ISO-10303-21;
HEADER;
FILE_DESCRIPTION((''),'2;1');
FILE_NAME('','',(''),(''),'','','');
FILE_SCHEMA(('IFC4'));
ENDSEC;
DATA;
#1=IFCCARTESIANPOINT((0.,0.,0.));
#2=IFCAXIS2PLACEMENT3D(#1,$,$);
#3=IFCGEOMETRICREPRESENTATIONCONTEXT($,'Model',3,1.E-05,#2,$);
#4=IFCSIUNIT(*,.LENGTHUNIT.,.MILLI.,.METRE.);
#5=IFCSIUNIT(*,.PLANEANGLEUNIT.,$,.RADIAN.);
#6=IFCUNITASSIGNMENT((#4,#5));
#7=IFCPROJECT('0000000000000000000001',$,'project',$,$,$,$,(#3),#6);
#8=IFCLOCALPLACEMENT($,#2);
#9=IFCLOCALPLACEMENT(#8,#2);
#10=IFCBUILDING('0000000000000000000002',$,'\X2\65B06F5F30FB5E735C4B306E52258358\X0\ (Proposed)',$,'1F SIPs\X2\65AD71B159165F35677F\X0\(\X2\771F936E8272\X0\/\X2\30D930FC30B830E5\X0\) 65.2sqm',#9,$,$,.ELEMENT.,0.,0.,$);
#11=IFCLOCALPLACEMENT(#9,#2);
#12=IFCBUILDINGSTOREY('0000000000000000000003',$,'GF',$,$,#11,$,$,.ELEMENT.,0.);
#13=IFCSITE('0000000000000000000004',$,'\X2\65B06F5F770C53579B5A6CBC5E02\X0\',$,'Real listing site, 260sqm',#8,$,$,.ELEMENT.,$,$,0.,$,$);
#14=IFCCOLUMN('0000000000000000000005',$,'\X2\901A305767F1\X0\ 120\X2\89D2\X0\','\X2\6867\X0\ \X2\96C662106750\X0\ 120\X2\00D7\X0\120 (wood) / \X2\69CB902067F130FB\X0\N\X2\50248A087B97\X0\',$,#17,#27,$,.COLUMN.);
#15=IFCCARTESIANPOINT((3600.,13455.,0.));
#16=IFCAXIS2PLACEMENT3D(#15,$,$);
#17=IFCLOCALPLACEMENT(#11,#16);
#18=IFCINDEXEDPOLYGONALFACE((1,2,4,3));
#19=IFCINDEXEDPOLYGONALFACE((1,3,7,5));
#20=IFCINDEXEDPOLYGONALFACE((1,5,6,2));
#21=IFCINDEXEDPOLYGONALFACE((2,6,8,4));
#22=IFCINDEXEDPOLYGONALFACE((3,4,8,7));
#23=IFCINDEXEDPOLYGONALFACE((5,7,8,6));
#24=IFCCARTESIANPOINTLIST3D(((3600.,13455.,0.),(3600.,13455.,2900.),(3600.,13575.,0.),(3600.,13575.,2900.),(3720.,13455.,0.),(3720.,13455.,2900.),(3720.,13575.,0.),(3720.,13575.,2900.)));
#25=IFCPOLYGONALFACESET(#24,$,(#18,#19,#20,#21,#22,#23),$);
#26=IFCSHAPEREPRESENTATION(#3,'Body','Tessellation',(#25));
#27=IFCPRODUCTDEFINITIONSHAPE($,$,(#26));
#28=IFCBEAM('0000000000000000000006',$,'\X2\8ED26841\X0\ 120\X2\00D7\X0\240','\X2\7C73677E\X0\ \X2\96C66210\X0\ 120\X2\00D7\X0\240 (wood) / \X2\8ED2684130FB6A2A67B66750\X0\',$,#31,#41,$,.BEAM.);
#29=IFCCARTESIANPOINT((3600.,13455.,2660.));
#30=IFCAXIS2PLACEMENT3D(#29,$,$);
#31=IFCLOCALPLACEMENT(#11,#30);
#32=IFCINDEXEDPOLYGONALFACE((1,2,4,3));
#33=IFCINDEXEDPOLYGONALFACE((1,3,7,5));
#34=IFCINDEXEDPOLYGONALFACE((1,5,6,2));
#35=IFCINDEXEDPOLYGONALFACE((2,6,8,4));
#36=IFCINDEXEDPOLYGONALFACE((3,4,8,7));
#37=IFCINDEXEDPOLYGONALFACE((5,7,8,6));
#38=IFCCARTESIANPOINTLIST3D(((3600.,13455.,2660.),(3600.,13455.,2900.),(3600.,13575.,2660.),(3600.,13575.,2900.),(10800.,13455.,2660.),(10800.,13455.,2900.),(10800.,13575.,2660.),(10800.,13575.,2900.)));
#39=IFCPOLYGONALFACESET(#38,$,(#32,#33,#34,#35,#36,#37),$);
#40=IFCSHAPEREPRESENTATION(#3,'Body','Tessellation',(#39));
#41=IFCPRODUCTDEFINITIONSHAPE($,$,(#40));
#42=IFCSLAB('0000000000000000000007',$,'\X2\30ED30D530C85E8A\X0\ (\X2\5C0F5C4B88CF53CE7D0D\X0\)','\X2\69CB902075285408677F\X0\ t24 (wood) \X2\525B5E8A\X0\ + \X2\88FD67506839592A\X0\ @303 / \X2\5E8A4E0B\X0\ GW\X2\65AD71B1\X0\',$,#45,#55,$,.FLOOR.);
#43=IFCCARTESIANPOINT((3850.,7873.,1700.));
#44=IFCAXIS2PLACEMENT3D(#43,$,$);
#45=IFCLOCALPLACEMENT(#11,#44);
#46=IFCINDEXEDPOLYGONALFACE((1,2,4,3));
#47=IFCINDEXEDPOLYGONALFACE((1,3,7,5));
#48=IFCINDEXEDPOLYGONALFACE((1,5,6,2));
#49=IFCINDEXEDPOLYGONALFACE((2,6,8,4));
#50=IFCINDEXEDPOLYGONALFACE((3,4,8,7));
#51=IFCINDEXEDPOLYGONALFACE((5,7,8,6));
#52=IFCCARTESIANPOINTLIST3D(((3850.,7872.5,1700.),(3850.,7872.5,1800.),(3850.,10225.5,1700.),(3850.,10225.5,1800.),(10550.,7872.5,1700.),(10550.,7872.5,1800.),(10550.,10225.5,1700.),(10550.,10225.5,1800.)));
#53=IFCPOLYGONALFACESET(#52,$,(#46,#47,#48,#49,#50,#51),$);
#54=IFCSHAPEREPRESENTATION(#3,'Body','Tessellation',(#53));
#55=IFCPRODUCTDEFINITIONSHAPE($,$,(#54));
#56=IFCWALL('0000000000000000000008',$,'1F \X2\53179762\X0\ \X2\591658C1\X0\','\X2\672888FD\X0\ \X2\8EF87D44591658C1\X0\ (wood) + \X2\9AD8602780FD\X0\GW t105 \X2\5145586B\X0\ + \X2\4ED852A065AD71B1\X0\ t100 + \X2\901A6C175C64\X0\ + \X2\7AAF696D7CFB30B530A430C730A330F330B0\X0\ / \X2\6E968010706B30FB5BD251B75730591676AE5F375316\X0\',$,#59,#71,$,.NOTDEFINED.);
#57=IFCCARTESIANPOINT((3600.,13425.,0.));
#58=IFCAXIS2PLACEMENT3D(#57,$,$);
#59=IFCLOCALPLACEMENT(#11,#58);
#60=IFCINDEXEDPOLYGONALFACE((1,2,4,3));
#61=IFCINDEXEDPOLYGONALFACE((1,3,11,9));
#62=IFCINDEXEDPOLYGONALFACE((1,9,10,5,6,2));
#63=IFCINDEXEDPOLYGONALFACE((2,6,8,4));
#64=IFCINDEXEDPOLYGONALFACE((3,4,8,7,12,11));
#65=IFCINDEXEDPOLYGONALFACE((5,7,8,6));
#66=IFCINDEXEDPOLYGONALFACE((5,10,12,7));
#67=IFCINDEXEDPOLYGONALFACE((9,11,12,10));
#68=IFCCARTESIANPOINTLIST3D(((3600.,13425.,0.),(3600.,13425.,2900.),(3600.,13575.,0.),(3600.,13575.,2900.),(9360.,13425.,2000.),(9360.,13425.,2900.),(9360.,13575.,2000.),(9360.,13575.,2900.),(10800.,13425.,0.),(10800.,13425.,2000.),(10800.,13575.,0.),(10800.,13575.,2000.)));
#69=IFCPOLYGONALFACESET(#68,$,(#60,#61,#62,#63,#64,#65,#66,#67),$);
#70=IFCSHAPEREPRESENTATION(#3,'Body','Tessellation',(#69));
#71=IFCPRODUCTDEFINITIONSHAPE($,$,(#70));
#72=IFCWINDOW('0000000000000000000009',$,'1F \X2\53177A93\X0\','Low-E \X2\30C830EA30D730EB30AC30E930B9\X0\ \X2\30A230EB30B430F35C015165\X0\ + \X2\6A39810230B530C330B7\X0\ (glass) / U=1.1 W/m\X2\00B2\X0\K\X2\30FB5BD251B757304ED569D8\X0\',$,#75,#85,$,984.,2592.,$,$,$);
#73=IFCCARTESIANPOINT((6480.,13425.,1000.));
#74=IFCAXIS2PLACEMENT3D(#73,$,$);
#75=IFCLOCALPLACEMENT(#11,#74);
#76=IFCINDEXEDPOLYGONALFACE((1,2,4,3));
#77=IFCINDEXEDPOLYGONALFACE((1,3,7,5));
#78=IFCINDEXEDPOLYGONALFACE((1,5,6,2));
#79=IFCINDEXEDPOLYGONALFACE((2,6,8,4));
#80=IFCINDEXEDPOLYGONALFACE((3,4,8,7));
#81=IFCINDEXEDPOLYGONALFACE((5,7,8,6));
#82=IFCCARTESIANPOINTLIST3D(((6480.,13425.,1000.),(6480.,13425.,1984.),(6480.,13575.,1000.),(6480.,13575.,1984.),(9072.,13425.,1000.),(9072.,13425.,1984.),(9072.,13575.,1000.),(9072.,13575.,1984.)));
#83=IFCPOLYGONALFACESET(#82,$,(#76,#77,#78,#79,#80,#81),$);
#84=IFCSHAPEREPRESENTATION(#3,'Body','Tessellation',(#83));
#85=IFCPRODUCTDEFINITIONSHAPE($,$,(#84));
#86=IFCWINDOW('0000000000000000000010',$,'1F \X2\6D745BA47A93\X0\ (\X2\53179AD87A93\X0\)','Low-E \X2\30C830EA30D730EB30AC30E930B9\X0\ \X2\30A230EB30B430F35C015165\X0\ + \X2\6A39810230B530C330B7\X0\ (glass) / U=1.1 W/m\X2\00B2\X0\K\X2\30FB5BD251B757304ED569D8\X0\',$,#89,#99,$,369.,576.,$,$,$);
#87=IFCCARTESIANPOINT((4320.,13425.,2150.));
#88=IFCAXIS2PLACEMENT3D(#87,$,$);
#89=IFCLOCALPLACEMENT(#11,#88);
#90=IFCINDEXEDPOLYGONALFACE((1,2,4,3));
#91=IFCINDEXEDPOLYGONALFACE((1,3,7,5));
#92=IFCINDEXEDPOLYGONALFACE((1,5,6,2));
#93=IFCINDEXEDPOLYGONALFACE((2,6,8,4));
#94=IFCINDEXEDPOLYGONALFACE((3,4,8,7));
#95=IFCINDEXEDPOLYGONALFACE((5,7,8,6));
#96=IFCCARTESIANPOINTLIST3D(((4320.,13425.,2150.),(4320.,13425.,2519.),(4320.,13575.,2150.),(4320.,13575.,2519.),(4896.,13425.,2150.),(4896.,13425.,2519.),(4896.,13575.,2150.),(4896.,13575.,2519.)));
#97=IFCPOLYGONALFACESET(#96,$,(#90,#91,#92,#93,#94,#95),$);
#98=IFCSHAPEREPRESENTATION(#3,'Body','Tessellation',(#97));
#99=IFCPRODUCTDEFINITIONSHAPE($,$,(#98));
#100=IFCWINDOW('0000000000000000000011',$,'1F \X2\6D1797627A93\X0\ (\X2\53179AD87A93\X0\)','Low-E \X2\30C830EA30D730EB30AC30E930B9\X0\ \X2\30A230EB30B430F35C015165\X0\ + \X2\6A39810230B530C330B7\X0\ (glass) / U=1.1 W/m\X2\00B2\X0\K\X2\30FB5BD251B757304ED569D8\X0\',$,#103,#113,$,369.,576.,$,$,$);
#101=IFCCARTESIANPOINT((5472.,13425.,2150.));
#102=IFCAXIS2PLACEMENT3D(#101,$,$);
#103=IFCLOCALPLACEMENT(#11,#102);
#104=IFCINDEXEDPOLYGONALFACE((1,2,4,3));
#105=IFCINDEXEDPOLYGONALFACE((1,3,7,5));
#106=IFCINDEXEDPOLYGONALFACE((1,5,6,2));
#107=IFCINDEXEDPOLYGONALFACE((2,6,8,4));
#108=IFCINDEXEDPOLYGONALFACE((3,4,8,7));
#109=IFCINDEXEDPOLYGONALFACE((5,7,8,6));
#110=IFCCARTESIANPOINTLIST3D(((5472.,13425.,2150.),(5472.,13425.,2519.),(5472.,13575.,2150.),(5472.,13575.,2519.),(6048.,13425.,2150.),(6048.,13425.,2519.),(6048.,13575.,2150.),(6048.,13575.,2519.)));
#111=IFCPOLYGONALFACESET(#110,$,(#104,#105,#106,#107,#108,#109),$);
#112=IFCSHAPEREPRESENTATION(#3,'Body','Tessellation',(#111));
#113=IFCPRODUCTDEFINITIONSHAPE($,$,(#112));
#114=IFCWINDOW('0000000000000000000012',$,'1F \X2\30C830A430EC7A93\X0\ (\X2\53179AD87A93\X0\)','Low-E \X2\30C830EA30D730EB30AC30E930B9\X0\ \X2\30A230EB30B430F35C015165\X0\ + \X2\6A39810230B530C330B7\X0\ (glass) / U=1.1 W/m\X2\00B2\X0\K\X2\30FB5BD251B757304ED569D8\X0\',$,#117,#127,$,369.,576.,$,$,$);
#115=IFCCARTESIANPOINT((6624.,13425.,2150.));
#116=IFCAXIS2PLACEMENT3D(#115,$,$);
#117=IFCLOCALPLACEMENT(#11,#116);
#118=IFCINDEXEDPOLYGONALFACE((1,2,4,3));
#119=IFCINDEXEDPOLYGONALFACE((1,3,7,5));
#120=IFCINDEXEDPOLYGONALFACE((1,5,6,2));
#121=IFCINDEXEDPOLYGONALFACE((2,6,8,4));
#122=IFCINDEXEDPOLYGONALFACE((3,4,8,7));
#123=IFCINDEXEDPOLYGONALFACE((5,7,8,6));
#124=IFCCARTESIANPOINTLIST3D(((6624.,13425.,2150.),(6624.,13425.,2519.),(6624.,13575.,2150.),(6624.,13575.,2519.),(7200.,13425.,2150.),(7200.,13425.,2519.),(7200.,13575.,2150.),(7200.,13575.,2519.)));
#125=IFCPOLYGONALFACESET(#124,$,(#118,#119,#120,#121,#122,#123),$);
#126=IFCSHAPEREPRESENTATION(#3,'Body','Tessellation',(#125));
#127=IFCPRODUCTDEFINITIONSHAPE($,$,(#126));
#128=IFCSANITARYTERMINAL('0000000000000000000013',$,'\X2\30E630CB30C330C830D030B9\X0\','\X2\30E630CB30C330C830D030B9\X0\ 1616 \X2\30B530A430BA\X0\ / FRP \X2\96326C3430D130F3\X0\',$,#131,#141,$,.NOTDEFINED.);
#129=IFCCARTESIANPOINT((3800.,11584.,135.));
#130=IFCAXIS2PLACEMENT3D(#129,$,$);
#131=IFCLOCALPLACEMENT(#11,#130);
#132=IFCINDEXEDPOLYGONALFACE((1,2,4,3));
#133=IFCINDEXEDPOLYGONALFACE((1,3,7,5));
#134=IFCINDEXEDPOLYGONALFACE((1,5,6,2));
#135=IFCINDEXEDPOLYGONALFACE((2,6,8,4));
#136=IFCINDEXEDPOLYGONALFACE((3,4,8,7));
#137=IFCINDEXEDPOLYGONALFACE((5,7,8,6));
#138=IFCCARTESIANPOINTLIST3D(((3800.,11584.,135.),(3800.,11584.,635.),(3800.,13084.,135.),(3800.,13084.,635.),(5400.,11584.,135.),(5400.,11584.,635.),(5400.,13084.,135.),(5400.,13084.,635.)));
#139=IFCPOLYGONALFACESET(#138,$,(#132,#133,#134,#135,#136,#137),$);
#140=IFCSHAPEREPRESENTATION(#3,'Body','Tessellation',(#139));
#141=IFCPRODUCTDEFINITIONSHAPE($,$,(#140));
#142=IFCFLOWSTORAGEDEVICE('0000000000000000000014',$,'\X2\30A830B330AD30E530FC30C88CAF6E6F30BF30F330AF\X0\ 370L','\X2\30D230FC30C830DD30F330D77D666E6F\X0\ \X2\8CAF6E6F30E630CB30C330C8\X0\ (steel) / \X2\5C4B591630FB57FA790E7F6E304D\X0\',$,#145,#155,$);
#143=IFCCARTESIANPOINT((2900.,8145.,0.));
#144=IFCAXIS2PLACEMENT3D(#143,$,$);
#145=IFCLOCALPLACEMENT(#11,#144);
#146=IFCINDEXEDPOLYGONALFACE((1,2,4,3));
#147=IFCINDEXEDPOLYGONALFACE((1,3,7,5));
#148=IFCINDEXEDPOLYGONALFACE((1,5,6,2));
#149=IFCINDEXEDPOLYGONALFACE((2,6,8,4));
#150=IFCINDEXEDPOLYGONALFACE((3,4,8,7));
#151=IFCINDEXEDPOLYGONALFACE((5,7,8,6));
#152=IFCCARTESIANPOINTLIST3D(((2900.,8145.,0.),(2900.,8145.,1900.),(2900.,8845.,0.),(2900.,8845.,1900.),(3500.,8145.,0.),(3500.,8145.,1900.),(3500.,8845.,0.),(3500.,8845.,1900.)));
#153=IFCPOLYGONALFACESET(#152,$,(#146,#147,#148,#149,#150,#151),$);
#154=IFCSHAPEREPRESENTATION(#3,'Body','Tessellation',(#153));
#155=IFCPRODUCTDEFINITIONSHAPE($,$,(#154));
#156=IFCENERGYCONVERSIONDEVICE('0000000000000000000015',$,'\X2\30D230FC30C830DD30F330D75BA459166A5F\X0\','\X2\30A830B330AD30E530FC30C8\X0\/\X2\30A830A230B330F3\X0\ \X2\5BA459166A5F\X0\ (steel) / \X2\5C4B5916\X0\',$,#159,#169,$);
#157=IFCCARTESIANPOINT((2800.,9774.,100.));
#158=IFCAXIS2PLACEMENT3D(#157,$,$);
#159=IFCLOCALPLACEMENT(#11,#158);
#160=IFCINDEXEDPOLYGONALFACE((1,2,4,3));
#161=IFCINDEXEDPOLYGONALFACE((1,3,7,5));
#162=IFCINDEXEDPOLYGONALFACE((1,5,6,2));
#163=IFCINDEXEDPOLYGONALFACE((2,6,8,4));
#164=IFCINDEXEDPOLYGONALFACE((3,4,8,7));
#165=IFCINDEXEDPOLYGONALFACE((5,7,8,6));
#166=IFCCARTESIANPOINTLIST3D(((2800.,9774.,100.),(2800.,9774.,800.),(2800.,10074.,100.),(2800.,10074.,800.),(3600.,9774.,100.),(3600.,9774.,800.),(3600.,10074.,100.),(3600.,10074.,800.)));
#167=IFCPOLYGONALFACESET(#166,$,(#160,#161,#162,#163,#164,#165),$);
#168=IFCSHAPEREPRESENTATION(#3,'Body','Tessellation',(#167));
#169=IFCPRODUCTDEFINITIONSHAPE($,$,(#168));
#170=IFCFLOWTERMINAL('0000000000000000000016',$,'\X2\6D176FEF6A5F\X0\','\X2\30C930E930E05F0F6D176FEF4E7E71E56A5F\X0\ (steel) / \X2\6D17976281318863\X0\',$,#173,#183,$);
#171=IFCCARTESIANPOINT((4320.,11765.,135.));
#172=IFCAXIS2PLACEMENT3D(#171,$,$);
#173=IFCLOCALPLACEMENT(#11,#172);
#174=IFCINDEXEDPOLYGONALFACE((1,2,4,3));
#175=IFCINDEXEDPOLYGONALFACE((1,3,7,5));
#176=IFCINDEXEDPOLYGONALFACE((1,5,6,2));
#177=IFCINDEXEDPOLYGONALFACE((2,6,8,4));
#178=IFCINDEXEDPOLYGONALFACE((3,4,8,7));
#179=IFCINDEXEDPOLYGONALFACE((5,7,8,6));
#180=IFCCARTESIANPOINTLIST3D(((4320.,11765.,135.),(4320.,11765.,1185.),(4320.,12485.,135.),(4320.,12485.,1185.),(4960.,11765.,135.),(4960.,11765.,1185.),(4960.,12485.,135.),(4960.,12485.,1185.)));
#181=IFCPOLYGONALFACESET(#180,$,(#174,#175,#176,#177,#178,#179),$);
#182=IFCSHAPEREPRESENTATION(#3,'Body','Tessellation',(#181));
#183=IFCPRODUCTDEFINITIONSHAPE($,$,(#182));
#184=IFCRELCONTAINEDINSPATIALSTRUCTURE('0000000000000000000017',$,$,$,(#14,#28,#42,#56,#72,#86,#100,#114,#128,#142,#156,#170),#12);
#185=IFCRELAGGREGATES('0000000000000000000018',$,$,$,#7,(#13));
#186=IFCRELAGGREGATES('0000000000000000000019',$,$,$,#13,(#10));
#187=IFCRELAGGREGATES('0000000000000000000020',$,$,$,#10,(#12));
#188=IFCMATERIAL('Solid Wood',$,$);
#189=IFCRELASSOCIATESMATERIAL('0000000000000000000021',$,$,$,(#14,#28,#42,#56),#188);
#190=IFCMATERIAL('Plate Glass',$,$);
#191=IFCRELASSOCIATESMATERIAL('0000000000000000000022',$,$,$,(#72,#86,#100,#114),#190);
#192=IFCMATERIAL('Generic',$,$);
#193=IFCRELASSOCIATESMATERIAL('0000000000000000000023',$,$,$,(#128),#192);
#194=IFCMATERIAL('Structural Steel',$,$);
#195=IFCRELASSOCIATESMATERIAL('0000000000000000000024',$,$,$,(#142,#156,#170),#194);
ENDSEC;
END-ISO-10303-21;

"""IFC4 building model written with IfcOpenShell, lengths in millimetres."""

from ifc_helpers import new_model, si_unit, frame, frame_2d, origin, place, context, project, spatial, rectangle, extrude, material, element, fill, save


model = new_model("IFC4")

# Units and contexts
model_context = context("Model", 3, precision=1e-05, world=origin())
ifc_project = project(units=[si_unit("LENGTHUNIT", "METRE", prefix="MILLI"), si_unit("PLANEANGLEUNIT", "RADIAN")], contexts=[model_context])

# Site, building, storey
site_placement = place(None, origin())
site = spatial("IfcSite", under=ifc_project, at=site_placement, Name="新潟県南魚沼市", ObjectType="Real listing site, 260sqm", CompositionType="ELEMENT", RefElevation=0.0)
building_placement = place(site_placement, origin())
building = spatial("IfcBuilding", under=site, at=building_placement, Name="新潟・平屋の別荘 (Proposed)", ObjectType="1F SIPs断熱外張板(真鍮色/ベージュ) 65.2sqm", CompositionType="ELEMENT", ElevationOfRefHeight=0.0, ElevationOfTerrain=0.0)
storey_placement = place(building_placement, origin())
storey = spatial("IfcBuildingStorey", under=building, at=storey_placement, Name="GF", CompositionType="ELEMENT", Elevation=0.0)

# Column
ifc_material_1 = material(Name="Solid Wood")
column_1_placement = place(storey_placement, frame((3600.0, 13455.0, 0.0)))
element("IfcColumn", 1, at=column_1_placement, inside=storey, material=ifc_material_1, Name="通し柱 120角", Description="桧 集成材 120×120 (wood) / 構造柱・N値計算", PredefinedType="COLUMN", context=model_context, shape_type="SweptSolid", body=[
    extrude(rectangle(XDim=120.0, YDim=120.0, at=frame_2d((60.0, 60.0))), frame((3600.0, 13455.0, 0.0)), (0.0, 0.0, 1.0), 2900.0),
])

# Beam
beam_1_placement = place(storey_placement, frame((3600.0, 13455.0, 2660.0)))
element("IfcBeam", 2, at=beam_1_placement, inside=storey, material=ifc_material_1, Name="軒桁 120×240", Description="米松 集成 120×240 (wood) / 軒桁・横架材", PredefinedType="BEAM", context=model_context, shape_type="SweptSolid", body=[
    extrude(rectangle(XDim=7200.0, YDim=120.0, at=frame_2d((3600.0, 60.0))), frame((3600.0, 13455.0, 2660.0)), (0.0, 0.0, 1.0), 240.0),
])

# Slab
slab_placement = place(storey_placement, frame((3850.0, 7873.0, 1700.0)))
element("IfcSlab", 3, at=slab_placement, inside=storey, material=ifc_material_1, Name="ロフト床 (小屋裏収納)", Description="構造用合板 t24 (wood) 剛床 + 製材根太 @303 / 床下 GW断熱", PredefinedType="FLOOR", context=model_context, shape_type="SweptSolid", body=[
    extrude(rectangle(XDim=6700.0, YDim=2353.0, at=frame_2d((3350.0, 1176.0))), frame((3850.0, 7873.0, 1700.0)), (0.0, 0.0, 1.0), 100.0),
])

# Wall, openings, windows
wall_1_placement = place(storey_placement, frame((3600.0, 13425.0, 0.0)))
wall_1 = element("IfcWall", 4, at=wall_1_placement, inside=storey, material=ifc_material_1, Name="1F 北面 外壁", Description="木製 軸組外壁 (wood) + 高性能GW t105 充填 + 付加断熱 t100 + 通気層 + 窯業系サイディング / 準耐火・寒冷地外皮強化", PredefinedType="NOTDEFINED", context=model_context, shape_type="SweptSolid", body=[
    extrude(rectangle(XDim=7200.0, YDim=150.0, at=frame_2d((3600.0, 75.0))), frame((3600.0, 13425.0, 0.0)), (0.0, 0.0, 1.0), 2900.0),
])
opening_1_placement = place(storey_placement, frame((6480.0, 13425.0, 1000.0)))
opening_1 = element("IfcOpeningElement", 5, at=opening_1_placement, cuts=wall_1, PredefinedType="NOTDEFINED", context=model_context, shape_type="SweptSolid", body=[
    extrude(rectangle(XDim=2592.0, YDim=150.0, at=frame_2d((1296.0, 75.0))), frame((6480.0, 13425.0, 1000.0)), (0.0, 0.0, 1.0), 984.0),
])
opening_2_placement = place(storey_placement, frame((4320.0, 13425.0, 2150.0)))
opening_2 = element("IfcOpeningElement", 6, at=opening_2_placement, cuts=wall_1, PredefinedType="NOTDEFINED", context=model_context, shape_type="SweptSolid", body=[
    extrude(rectangle(XDim=576.0, YDim=150.0, at=frame_2d((288.0, 75.0))), frame((4320.0, 13425.0, 2150.0)), (0.0, 0.0, 1.0), 369.0),
])
opening_3_placement = place(storey_placement, frame((5472.0, 13425.0, 2150.0)))
opening_3 = element("IfcOpeningElement", 7, at=opening_3_placement, cuts=wall_1, PredefinedType="NOTDEFINED", context=model_context, shape_type="SweptSolid", body=[
    extrude(rectangle(XDim=576.0, YDim=150.0, at=frame_2d((288.0, 75.0))), frame((5472.0, 13425.0, 2150.0)), (0.0, 0.0, 1.0), 369.0),
])
opening_4_placement = place(storey_placement, frame((6624.0, 13425.0, 2150.0)))
opening_4 = element("IfcOpeningElement", 8, at=opening_4_placement, cuts=wall_1, PredefinedType="NOTDEFINED", context=model_context, shape_type="SweptSolid", body=[
    extrude(rectangle(XDim=576.0, YDim=150.0, at=frame_2d((288.0, 75.0))), frame((6624.0, 13425.0, 2150.0)), (0.0, 0.0, 1.0), 369.0),
])
ifc_material_2 = material(Name="Plate Glass")
window_1_placement = place(storey_placement, frame((6480.0, 13425.0, 1000.0)))
window_1 = element("IfcWindow", 9, at=window_1_placement, inside=storey, material=ifc_material_2, Name="1F 北窓", Description="Low-E トリプルガラス アルゴン封入 + 樹脂サッシ (glass) / U=1.1 W/m²K・寒冷地仕様", OverallHeight=984.0, OverallWidth=2592.0, context=model_context, shape_type="SweptSolid", body=[
    extrude(rectangle(XDim=2592.0, YDim=150.0, at=frame_2d((1296.0, 75.0))), frame((6480.0, 13425.0, 1000.0)), (0.0, 0.0, 1.0), 984.0),
])
fill(opening_1, window_1)
window_2_placement = place(storey_placement, frame((4320.0, 13425.0, 2150.0)))
window_2 = element("IfcWindow", 10, at=window_2_placement, inside=storey, material=ifc_material_2, Name="1F 浴室窓 (北高窓)", Description="Low-E トリプルガラス アルゴン封入 + 樹脂サッシ (glass) / U=1.1 W/m²K・寒冷地仕様", OverallHeight=369.0, OverallWidth=576.0, context=model_context, shape_type="SweptSolid", body=[
    extrude(rectangle(XDim=576.0, YDim=150.0, at=frame_2d((288.0, 75.0))), frame((4320.0, 13425.0, 2150.0)), (0.0, 0.0, 1.0), 369.0),
])
fill(opening_2, window_2)
window_3_placement = place(storey_placement, frame((5472.0, 13425.0, 2150.0)))
window_3 = element("IfcWindow", 11, at=window_3_placement, inside=storey, material=ifc_material_2, Name="1F 洗面窓 (北高窓)", Description="Low-E トリプルガラス アルゴン封入 + 樹脂サッシ (glass) / U=1.1 W/m²K・寒冷地仕様", OverallHeight=369.0, OverallWidth=576.0, context=model_context, shape_type="SweptSolid", body=[
    extrude(rectangle(XDim=576.0, YDim=150.0, at=frame_2d((288.0, 75.0))), frame((5472.0, 13425.0, 2150.0)), (0.0, 0.0, 1.0), 369.0),
])
fill(opening_3, window_3)
window_4_placement = place(storey_placement, frame((6624.0, 13425.0, 2150.0)))
window_4 = element("IfcWindow", 12, at=window_4_placement, inside=storey, material=ifc_material_2, Name="1F トイレ窓 (北高窓)", Description="Low-E トリプルガラス アルゴン封入 + 樹脂サッシ (glass) / U=1.1 W/m²K・寒冷地仕様", OverallHeight=369.0, OverallWidth=576.0, context=model_context, shape_type="SweptSolid", body=[
    extrude(rectangle(XDim=576.0, YDim=150.0, at=frame_2d((288.0, 75.0))), frame((6624.0, 13425.0, 2150.0)), (0.0, 0.0, 1.0), 369.0),
])
fill(opening_4, window_4)

# Sanitary terminal
ifc_material_3 = material(Name="Generic")
sanitary_terminal_placement = place(storey_placement, frame((3800.0, 11584.0, 135.0)))
element("IfcSanitaryTerminal", 13, at=sanitary_terminal_placement, inside=storey, material=ifc_material_3, Name="ユニットバス", Description="ユニットバス 1616 サイズ / FRP 防水パン", PredefinedType="NOTDEFINED", context=model_context, shape_type="SweptSolid", body=[
    extrude(rectangle(XDim=1600.0, YDim=1500.0, at=frame_2d((800.0, 750.0))), frame((3800.0, 11584.0, 135.0)), (0.0, 0.0, 1.0), 500.0),
])

# Flow storage device
ifc_material_4 = material(Name="Structural Steel")
flow_storage_device_placement = place(storey_placement, frame((2900.0, 8145.0, 0.0)))
element("IfcFlowStorageDevice", 14, at=flow_storage_device_placement, inside=storey, material=ifc_material_4, Name="エコキュート貯湯タンク 370L", Description="ヒートポンプ給湯 貯湯ユニット (steel) / 屋外・基礎置き", context=model_context, shape_type="SweptSolid", body=[
    extrude(rectangle(XDim=600.0, YDim=700.0, at=frame_2d((300.0, 350.0))), frame((2900.0, 8145.0, 0.0)), (0.0, 0.0, 1.0), 1900.0),
])

# Energy conversion device
energy_conversion_device_placement = place(storey_placement, frame((2800.0, 9774.0, 100.0)))
element("IfcEnergyConversionDevice", 15, at=energy_conversion_device_placement, inside=storey, material=ifc_material_4, Name="ヒートポンプ室外機", Description="エコキュート/エアコン 室外機 (steel) / 屋外", context=model_context, shape_type="SweptSolid", body=[
    extrude(rectangle(XDim=800.0, YDim=300.0, at=frame_2d((400.0, 150.0))), frame((2800.0, 9774.0, 100.0)), (0.0, 0.0, 1.0), 700.0),
])

# Flow terminal
flow_terminal_placement = place(storey_placement, frame((4320.0, 11765.0, 135.0)))
element("IfcFlowTerminal", 16, at=flow_terminal_placement, inside=storey, material=ifc_material_4, Name="洗濯機", Description="ドラム式洗濯乾燥機 (steel) / 洗面脱衣", context=model_context, shape_type="SweptSolid", body=[
    extrude(rectangle(XDim=640.0, YDim=720.0, at=frame_2d((320.0, 360.0))), frame((4320.0, 11765.0, 135.0)), (0.0, 0.0, 1.0), 1050.0),
])

save(model, "model.ifc")
